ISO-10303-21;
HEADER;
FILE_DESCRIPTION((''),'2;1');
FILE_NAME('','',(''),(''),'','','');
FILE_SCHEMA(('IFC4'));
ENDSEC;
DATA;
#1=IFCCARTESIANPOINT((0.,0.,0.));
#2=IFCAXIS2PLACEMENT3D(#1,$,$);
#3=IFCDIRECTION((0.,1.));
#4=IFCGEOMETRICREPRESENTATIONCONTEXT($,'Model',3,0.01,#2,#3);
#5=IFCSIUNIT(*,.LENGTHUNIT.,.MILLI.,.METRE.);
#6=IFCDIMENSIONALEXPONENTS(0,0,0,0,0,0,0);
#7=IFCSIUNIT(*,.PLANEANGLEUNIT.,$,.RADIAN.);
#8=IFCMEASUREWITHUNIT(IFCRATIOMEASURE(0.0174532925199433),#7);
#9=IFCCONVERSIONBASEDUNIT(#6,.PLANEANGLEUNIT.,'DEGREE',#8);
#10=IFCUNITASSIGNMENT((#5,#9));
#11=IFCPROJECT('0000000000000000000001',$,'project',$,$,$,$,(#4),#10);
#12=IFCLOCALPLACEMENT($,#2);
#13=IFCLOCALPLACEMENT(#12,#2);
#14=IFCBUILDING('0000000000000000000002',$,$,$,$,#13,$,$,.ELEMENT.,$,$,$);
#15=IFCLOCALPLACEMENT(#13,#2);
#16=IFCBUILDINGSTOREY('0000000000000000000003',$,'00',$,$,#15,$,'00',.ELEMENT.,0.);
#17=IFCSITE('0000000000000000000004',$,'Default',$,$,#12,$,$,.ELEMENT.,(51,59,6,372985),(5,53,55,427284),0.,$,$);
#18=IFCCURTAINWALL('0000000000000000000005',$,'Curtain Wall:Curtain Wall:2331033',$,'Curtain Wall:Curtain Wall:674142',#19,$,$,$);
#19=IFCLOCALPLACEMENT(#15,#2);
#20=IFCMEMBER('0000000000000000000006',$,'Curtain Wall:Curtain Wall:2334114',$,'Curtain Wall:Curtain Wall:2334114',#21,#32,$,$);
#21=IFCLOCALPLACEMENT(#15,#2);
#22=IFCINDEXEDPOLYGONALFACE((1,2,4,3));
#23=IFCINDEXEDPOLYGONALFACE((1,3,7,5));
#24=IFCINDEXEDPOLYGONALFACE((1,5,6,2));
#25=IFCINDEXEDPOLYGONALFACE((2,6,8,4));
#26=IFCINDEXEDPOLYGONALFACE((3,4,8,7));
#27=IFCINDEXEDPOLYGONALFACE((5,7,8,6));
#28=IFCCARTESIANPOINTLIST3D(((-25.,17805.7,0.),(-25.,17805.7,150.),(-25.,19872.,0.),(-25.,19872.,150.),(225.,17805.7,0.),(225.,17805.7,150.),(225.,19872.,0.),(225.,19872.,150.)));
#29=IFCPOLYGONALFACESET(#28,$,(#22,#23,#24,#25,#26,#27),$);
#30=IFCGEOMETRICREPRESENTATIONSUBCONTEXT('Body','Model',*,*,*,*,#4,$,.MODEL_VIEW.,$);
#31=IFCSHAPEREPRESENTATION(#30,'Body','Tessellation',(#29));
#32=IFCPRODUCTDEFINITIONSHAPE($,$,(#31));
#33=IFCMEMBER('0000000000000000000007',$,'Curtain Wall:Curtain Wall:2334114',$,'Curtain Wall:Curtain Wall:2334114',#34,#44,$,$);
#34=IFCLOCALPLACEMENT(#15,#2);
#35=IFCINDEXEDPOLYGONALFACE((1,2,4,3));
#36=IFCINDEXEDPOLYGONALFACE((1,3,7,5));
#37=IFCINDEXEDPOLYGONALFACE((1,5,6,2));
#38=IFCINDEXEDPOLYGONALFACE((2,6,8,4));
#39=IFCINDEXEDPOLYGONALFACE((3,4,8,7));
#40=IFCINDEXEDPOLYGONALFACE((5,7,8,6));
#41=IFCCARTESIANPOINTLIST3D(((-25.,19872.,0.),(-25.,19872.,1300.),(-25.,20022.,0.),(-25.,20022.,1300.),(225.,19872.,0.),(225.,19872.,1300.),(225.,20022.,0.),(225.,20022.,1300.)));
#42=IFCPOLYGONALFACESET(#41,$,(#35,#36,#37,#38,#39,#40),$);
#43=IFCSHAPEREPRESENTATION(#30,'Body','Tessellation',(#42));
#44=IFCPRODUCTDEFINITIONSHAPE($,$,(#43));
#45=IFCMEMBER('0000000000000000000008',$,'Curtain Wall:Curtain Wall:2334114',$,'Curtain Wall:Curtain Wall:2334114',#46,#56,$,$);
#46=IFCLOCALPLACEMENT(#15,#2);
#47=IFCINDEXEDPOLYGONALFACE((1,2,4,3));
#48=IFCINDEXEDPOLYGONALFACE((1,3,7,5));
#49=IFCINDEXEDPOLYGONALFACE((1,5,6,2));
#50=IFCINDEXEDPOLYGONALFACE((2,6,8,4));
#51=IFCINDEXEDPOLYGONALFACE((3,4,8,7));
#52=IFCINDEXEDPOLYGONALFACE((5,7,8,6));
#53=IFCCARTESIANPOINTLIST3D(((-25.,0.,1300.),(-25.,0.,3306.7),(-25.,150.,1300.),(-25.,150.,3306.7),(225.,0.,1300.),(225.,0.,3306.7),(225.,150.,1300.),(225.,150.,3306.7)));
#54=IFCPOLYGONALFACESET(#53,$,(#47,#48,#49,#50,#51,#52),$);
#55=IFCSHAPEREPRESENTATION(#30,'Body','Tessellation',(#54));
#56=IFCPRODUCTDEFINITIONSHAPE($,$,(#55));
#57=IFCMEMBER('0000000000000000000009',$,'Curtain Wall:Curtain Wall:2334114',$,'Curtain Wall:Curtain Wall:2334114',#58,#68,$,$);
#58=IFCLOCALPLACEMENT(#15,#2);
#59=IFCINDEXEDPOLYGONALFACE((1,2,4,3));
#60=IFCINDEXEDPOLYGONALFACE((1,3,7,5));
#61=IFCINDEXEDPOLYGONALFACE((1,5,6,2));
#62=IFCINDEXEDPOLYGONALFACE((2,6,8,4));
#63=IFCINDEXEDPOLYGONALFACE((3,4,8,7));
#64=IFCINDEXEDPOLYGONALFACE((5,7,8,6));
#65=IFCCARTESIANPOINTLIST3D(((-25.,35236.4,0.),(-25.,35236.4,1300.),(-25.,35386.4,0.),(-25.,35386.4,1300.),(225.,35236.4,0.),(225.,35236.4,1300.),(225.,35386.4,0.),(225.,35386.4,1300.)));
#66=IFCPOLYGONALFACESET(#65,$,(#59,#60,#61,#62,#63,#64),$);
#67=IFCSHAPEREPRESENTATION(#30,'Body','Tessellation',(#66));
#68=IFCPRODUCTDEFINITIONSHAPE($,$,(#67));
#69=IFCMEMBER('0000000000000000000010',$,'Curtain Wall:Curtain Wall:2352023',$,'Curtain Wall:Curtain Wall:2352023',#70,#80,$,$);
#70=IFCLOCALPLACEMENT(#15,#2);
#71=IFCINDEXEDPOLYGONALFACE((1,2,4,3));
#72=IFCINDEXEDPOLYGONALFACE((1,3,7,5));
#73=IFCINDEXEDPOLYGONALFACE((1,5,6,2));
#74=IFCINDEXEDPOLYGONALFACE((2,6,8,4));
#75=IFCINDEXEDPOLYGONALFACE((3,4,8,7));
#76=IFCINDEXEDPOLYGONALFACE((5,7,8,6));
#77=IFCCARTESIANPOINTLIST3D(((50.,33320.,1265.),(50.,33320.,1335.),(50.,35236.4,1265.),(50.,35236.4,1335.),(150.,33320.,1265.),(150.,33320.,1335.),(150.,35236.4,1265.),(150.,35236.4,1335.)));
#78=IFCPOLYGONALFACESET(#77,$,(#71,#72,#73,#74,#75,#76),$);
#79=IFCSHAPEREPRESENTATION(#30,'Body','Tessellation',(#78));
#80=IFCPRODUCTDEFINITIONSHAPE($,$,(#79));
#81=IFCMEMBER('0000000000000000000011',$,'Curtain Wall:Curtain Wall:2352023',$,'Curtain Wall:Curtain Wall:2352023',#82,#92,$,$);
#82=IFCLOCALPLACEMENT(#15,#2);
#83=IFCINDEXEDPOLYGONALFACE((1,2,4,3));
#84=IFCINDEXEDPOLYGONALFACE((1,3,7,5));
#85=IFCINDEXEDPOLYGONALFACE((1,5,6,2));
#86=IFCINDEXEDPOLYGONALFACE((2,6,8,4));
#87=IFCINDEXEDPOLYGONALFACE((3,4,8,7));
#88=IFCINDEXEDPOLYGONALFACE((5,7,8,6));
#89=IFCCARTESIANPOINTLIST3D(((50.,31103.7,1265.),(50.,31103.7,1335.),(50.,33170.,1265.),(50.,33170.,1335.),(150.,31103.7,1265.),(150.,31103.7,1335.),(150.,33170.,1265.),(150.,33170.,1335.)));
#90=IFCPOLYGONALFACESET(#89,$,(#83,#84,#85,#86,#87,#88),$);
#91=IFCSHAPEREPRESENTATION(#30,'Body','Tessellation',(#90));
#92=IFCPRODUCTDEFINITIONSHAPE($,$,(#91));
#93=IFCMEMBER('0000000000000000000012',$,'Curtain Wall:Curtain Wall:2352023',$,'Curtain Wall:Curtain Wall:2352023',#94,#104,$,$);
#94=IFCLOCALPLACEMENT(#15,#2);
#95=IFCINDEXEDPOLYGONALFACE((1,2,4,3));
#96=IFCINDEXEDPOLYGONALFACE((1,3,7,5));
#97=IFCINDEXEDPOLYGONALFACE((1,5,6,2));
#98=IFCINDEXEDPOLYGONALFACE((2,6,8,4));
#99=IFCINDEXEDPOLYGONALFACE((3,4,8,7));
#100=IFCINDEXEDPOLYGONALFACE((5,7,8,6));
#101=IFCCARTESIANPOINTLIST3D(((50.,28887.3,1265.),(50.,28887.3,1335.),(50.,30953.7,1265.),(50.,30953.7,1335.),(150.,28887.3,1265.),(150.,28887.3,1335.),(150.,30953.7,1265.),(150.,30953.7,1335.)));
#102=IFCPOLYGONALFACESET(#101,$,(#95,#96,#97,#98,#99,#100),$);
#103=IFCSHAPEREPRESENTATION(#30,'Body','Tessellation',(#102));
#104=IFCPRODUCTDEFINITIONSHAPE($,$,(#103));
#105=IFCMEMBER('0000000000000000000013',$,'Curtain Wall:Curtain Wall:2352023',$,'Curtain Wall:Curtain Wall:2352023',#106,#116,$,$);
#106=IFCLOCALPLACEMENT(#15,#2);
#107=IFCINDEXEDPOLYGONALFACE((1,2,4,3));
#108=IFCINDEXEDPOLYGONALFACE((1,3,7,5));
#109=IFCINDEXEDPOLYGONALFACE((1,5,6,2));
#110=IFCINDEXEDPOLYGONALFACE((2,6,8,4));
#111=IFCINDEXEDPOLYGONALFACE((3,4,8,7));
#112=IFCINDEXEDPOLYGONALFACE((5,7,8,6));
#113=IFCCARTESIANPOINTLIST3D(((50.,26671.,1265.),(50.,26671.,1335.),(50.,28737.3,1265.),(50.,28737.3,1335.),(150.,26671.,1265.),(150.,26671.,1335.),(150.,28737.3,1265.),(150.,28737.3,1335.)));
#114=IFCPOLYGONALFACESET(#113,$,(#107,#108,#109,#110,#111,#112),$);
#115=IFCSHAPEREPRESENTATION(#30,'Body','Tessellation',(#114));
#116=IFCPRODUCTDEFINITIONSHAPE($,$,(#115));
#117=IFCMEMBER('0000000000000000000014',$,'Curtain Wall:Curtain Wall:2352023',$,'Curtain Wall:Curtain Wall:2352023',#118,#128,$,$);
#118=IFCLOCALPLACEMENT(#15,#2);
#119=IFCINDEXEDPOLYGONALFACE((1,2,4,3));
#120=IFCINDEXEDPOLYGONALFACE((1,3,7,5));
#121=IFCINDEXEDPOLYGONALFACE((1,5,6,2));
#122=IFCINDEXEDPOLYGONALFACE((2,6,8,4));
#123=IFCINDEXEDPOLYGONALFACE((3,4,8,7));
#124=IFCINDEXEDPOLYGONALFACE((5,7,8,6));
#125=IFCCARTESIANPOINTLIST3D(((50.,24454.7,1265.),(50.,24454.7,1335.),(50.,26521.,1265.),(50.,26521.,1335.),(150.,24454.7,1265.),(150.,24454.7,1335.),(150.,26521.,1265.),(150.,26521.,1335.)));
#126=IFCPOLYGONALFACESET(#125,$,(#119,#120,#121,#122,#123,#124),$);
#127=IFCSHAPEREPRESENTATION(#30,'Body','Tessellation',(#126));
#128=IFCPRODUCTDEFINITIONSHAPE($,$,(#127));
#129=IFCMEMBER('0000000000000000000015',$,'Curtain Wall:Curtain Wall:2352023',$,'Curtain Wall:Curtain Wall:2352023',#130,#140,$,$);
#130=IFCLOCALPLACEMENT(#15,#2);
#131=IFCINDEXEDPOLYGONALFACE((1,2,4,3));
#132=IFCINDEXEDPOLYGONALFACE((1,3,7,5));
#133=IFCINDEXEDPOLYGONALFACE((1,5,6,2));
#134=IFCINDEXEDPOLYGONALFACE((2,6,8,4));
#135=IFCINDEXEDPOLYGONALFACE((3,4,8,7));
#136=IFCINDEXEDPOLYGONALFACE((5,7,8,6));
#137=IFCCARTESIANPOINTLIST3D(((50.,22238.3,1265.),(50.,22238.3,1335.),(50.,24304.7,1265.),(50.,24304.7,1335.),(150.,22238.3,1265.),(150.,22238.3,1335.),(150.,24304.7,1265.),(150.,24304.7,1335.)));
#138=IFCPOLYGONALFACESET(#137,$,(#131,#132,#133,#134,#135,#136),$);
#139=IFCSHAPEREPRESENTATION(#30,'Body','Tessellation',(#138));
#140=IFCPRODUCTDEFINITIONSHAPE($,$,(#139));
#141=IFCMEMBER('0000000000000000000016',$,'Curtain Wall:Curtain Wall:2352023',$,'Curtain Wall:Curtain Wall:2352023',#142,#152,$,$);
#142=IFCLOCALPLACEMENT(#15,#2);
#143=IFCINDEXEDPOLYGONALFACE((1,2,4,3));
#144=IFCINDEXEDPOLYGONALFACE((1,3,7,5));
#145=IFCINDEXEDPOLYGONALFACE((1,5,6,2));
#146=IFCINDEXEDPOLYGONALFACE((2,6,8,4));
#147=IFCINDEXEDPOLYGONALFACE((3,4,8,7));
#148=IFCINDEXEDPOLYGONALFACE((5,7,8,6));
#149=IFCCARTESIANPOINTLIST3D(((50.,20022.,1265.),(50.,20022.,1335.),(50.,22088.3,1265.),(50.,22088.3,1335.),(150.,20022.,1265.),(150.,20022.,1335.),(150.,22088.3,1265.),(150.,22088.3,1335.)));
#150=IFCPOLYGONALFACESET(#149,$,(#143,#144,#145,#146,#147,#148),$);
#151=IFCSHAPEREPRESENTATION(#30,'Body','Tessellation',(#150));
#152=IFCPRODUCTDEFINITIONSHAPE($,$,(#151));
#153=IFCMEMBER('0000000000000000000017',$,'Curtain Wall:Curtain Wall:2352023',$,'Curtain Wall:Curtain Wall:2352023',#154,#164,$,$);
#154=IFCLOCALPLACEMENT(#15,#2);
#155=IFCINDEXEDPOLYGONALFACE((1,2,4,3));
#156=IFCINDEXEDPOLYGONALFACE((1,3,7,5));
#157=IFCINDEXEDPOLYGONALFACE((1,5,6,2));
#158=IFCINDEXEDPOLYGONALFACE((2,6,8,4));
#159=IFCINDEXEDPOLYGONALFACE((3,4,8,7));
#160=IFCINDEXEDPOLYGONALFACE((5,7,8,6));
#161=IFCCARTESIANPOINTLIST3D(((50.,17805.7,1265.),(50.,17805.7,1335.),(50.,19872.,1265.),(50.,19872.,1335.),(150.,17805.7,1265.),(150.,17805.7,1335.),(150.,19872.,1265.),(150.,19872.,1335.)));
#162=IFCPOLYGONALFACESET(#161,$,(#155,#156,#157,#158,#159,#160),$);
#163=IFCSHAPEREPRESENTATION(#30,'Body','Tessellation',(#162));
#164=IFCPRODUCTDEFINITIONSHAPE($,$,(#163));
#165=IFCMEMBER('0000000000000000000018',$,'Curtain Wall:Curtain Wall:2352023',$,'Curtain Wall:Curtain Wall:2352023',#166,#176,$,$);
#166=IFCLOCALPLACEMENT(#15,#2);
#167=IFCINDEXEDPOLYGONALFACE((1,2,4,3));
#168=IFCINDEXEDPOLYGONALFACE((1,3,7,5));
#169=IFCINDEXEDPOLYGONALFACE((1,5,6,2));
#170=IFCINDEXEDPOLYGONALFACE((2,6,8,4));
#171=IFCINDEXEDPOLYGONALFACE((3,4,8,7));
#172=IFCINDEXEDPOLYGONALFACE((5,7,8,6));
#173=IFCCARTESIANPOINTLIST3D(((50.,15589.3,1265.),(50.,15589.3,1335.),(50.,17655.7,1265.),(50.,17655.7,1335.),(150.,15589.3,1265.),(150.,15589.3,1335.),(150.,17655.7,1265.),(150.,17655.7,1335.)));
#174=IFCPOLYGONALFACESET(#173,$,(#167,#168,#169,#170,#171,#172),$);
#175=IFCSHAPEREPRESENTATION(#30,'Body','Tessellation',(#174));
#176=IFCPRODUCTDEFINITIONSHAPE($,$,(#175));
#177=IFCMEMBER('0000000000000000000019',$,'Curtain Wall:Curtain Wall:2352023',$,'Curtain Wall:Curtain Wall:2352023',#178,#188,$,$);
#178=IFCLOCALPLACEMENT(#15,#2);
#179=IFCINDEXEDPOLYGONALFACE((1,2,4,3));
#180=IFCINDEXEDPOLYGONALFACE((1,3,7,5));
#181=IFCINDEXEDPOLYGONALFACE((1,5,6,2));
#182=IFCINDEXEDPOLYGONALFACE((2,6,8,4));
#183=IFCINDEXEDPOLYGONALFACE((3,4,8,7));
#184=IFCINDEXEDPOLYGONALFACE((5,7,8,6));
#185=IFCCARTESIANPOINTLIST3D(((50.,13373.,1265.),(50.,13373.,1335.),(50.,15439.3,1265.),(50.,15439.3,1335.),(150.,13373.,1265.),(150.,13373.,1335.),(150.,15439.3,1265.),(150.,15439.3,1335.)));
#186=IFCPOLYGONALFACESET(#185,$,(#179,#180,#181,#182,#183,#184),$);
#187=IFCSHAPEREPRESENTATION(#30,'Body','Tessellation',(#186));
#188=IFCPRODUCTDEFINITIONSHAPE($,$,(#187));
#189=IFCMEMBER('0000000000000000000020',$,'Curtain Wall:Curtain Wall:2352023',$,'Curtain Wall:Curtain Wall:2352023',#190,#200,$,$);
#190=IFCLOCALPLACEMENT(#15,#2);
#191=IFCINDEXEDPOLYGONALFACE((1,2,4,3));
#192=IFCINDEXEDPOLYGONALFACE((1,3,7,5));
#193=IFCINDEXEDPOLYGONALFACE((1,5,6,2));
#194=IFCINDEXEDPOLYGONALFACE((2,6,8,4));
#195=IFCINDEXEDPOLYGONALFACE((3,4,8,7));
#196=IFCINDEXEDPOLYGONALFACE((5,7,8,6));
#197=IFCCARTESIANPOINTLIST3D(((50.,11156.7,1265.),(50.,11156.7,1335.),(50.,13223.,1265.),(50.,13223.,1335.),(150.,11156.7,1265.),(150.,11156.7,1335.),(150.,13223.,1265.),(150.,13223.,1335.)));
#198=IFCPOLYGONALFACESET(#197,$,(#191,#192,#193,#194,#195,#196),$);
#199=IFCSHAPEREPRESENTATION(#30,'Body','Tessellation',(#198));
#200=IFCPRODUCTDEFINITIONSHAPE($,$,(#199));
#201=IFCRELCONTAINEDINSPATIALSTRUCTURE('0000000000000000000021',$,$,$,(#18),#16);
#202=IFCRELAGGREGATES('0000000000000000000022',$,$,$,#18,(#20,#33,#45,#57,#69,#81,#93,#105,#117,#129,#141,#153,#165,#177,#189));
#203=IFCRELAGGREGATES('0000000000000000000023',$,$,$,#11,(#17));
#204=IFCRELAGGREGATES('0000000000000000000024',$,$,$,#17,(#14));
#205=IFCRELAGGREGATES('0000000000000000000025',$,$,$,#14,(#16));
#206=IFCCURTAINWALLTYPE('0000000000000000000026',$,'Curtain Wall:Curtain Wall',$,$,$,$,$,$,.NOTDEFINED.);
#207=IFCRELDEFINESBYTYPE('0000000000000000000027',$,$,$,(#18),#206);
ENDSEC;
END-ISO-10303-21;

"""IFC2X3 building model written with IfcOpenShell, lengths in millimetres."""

from ifc_helpers import new_model, entity, si_unit, converted_unit, direction, frame, frame_2d, origin, origin_2d_with_axis, place, context, subcontext, project, spatial, rectangle, extrude, type_object, element, aggregate, save


model = new_model("IFC2X3")

# Units and contexts
model_context = context("Model", 3, precision=0.01, world=origin(), true_north=direction((0.0, 1.0)))
body_context = subcontext(model_context, "Body", "Model", "MODEL_VIEW")
ifc_project = project(units=[si_unit("LENGTHUNIT", "METRE", prefix="MILLI"), converted_unit("PLANEANGLEUNIT", "DEGREE", entity("IfcRatioMeasure", 0.0174532925199433), si_unit("PLANEANGLEUNIT", "RADIAN"), dimensions=[0, 0, 0, 0, 0, 0, 0])], contexts=[model_context])

# Site, building, storey
site_placement = place(None, origin())
site = spatial("IfcSite", under=ifc_project, at=site_placement, Name="Default", CompositionType="ELEMENT", RefLatitude=(51, 59, 6, 372985), RefLongitude=(5, 53, 55, 427284), RefElevation=0.0)
building_placement = place(site_placement, origin())
building = spatial("IfcBuilding", under=site, at=building_placement, CompositionType="ELEMENT")
storey_placement = place(building_placement, origin())
storey = spatial("IfcBuildingStorey", under=building, at=storey_placement, Name="00", LongName="00", CompositionType="ELEMENT", Elevation=0.0)

# Curtain wall, members
curtain_wall_type = type_object("IfcCurtainWallType", Name="Curtain Wall:Curtain Wall", PredefinedType="NOTDEFINED")
curtain_wall_placement = place(storey_placement, origin())
curtain_wall = element("IfcCurtainWall", 1, at=curtain_wall_placement, inside=storey, type_object=curtain_wall_type, Name="Curtain Wall:Curtain Wall:2331033", ObjectType="Curtain Wall:Curtain Wall:674142")
member_1_placement = place(curtain_wall_placement, origin())
member_1 = element("IfcMember", 2, at=member_1_placement, Name="Curtain Wall:Curtain Wall:2334114", ObjectType="Curtain Wall:Curtain Wall:2334114", context=body_context, shape_type="SweptSolid", body=[
    extrude(rectangle(XDim=150.0, YDim=250.0, at=origin_2d_with_axis()), frame((100.0, 19872.0, 75.0), z_axis=(0.0, -1.0, 0.0), x_axis=(0.0, 0.0, -1.0)), (0.0, 0.0, 1.0), 2066.3),
])
member_2_placement = place(curtain_wall_placement, origin())
member_2 = element("IfcMember", 3, at=member_2_placement, Name="Curtain Wall:Curtain Wall:2334114", ObjectType="Curtain Wall:Curtain Wall:2334114", context=body_context, shape_type="SweptSolid", body=[
    extrude(rectangle(XDim=250.0, YDim=150.0, at=frame_2d((0.0, 0.0), x_axis=(1.0, 0.0))), frame((100.0, 19947.0, 0.0), z_axis=(0.0, 0.0, 1.0), x_axis=(-1.0, 0.0, 0.0)), (0.0, 0.0, 1.0), 1300.0),
])
member_3_placement = place(curtain_wall_placement, origin())
member_3 = element("IfcMember", 4, at=member_3_placement, Name="Curtain Wall:Curtain Wall:2334114", ObjectType="Curtain Wall:Curtain Wall:2334114", context=body_context, shape_type="SweptSolid", body=[
    extrude(rectangle(XDim=250.0, YDim=150.0, at=frame_2d((0.0, 0.0), x_axis=(1.0, 0.0))), frame((100.0, 75.0, 1300.0), z_axis=(0.0, 0.0, 1.0), x_axis=(-1.0, 0.0, 0.0)), (0.0, 0.0, 1.0), 2006.7),
])
member_4_placement = place(curtain_wall_placement, origin())
member_4 = element("IfcMember", 5, at=member_4_placement, Name="Curtain Wall:Curtain Wall:2334114", ObjectType="Curtain Wall:Curtain Wall:2334114", context=body_context, shape_type="SweptSolid", body=[
    extrude(rectangle(XDim=250.0, YDim=150.0, at=origin_2d_with_axis()), frame((100.0, 35311.4, 1300.0), z_axis=(0.0, 0.0, -1.0), x_axis=(-1.0, 0.0, 0.0)), (0.0, 0.0, 1.0), 1300.0),
])
member_5_placement = place(curtain_wall_placement, origin())
member_5 = element("IfcMember", 6, at=member_5_placement, Name="Curtain Wall:Curtain Wall:2352023", ObjectType="Curtain Wall:Curtain Wall:2352023", context=body_context, shape_type="SweptSolid", body=[
    extrude(rectangle(XDim=70.0, YDim=100.0, at=frame_2d((0.0, 0.0), x_axis=(1.0, 0.0))), frame((100.0, 33320.0, 1300.0), z_axis=(0.0, 1.0, 0.0), x_axis=(0.0, 0.0, -1.0)), (0.0, 0.0, 1.0), 1916.3),
])
member_6_placement = place(curtain_wall_placement, origin())
member_6 = element("IfcMember", 7, at=member_6_placement, Name="Curtain Wall:Curtain Wall:2352023", ObjectType="Curtain Wall:Curtain Wall:2352023", context=body_context, shape_type="SweptSolid", body=[
    extrude(rectangle(XDim=70.0, YDim=100.0, at=origin_2d_with_axis()), frame((100.0, 31103.7, 1300.0), z_axis=(0.0, 1.0, 0.0), x_axis=(0.0, 0.0, -1.0)), (0.0, 0.0, 1.0), 2066.3),
])
member_7_placement = place(curtain_wall_placement, origin())
member_7 = element("IfcMember", 8, at=member_7_placement, Name="Curtain Wall:Curtain Wall:2352023", ObjectType="Curtain Wall:Curtain Wall:2352023", context=body_context, shape_type="SweptSolid", body=[
    extrude(rectangle(XDim=70.0, YDim=100.0, at=frame_2d((0.0, 0.0), x_axis=(1.0, 0.0))), frame((100.0, 28887.3, 1300.0), z_axis=(0.0, 1.0, 0.0), x_axis=(0.0, 0.0, -1.0)), (0.0, 0.0, 1.0), 2066.3),
])
member_8_placement = place(curtain_wall_placement, origin())
member_8 = element("IfcMember", 9, at=member_8_placement, Name="Curtain Wall:Curtain Wall:2352023", ObjectType="Curtain Wall:Curtain Wall:2352023", context=body_context, shape_type="SweptSolid", body=[
    extrude(rectangle(XDim=70.0, YDim=100.0, at=origin_2d_with_axis()), frame((100.0, 26671.0, 1300.0), z_axis=(0.0, 1.0, 0.0), x_axis=(0.0, 0.0, -1.0)), (0.0, 0.0, 1.0), 2066.3),
])
member_9_placement = place(curtain_wall_placement, origin())
member_9 = element("IfcMember", 10, at=member_9_placement, Name="Curtain Wall:Curtain Wall:2352023", ObjectType="Curtain Wall:Curtain Wall:2352023", context=body_context, shape_type="SweptSolid", body=[
    extrude(rectangle(XDim=70.0, YDim=100.0, at=origin_2d_with_axis()), frame((100.0, 24454.7, 1300.0), z_axis=(0.0, 1.0, 0.0), x_axis=(0.0, 0.0, -1.0)), (0.0, 0.0, 1.0), 2066.3),
])
member_10_placement = place(curtain_wall_placement, origin())
member_10 = element("IfcMember", 11, at=member_10_placement, Name="Curtain Wall:Curtain Wall:2352023", ObjectType="Curtain Wall:Curtain Wall:2352023", context=body_context, shape_type="SweptSolid", body=[
    extrude(rectangle(XDim=70.0, YDim=100.0, at=frame_2d((0.0, 0.0), x_axis=(1.0, 0.0))), frame((100.0, 22238.3, 1300.0), z_axis=(0.0, 1.0, 0.0), x_axis=(0.0, 0.0, -1.0)), (0.0, 0.0, 1.0), 2066.3),
])
member_11_placement = place(curtain_wall_placement, origin())
member_11 = element("IfcMember", 12, at=member_11_placement, Name="Curtain Wall:Curtain Wall:2352023", ObjectType="Curtain Wall:Curtain Wall:2352023", context=body_context, shape_type="SweptSolid", body=[
    extrude(rectangle(XDim=70.0, YDim=100.0, at=origin_2d_with_axis()), frame((100.0, 20022.0, 1300.0), z_axis=(0.0, 1.0, 0.0), x_axis=(0.0, 0.0, -1.0)), (0.0, 0.0, 1.0), 2066.3),
])
member_12_placement = place(curtain_wall_placement, origin())
member_12 = element("IfcMember", 13, at=member_12_placement, Name="Curtain Wall:Curtain Wall:2352023", ObjectType="Curtain Wall:Curtain Wall:2352023", context=body_context, shape_type="SweptSolid", body=[
    extrude(rectangle(XDim=70.0, YDim=100.0, at=frame_2d((0.0, 0.0), x_axis=(1.0, 0.0))), frame((100.0, 17805.7, 1300.0), z_axis=(0.0, 1.0, 0.0), x_axis=(0.0, 0.0, -1.0)), (0.0, 0.0, 1.0), 2066.3),
])
member_13_placement = place(curtain_wall_placement, origin())
member_13 = element("IfcMember", 14, at=member_13_placement, Name="Curtain Wall:Curtain Wall:2352023", ObjectType="Curtain Wall:Curtain Wall:2352023", context=body_context, shape_type="SweptSolid", body=[
    extrude(rectangle(XDim=70.0, YDim=100.0, at=origin_2d_with_axis()), frame((100.0, 15589.3, 1300.0), z_axis=(0.0, 1.0, 0.0), x_axis=(0.0, 0.0, -1.0)), (0.0, 0.0, 1.0), 2066.3),
])
member_14_placement = place(curtain_wall_placement, origin())
member_14 = element("IfcMember", 15, at=member_14_placement, Name="Curtain Wall:Curtain Wall:2352023", ObjectType="Curtain Wall:Curtain Wall:2352023", context=body_context, shape_type="SweptSolid", body=[
    extrude(rectangle(XDim=70.0, YDim=100.0, at=origin_2d_with_axis()), frame((100.0, 13373.0, 1300.0), z_axis=(0.0, 1.0, 0.0), x_axis=(0.0, 0.0, -1.0)), (0.0, 0.0, 1.0), 2066.3),
])
member_15_placement = place(curtain_wall_placement, origin())
member_15 = element("IfcMember", 16, at=member_15_placement, Name="Curtain Wall:Curtain Wall:2352023", ObjectType="Curtain Wall:Curtain Wall:2352023", context=body_context, shape_type="SweptSolid", body=[
    extrude(rectangle(XDim=70.0, YDim=100.0, at=origin_2d_with_axis()), frame((100.0, 11156.7, 1300.0), z_axis=(0.0, 1.0, 0.0), x_axis=(0.0, 0.0, -1.0)), (0.0, 0.0, 1.0), 2066.3),
])
aggregate(curtain_wall, [member_1, member_2, member_3, member_4, member_5, member_6, member_7, member_8, member_9, member_10, member_11, member_12, member_13, member_14, member_15])

save(model, "model.ifc")
